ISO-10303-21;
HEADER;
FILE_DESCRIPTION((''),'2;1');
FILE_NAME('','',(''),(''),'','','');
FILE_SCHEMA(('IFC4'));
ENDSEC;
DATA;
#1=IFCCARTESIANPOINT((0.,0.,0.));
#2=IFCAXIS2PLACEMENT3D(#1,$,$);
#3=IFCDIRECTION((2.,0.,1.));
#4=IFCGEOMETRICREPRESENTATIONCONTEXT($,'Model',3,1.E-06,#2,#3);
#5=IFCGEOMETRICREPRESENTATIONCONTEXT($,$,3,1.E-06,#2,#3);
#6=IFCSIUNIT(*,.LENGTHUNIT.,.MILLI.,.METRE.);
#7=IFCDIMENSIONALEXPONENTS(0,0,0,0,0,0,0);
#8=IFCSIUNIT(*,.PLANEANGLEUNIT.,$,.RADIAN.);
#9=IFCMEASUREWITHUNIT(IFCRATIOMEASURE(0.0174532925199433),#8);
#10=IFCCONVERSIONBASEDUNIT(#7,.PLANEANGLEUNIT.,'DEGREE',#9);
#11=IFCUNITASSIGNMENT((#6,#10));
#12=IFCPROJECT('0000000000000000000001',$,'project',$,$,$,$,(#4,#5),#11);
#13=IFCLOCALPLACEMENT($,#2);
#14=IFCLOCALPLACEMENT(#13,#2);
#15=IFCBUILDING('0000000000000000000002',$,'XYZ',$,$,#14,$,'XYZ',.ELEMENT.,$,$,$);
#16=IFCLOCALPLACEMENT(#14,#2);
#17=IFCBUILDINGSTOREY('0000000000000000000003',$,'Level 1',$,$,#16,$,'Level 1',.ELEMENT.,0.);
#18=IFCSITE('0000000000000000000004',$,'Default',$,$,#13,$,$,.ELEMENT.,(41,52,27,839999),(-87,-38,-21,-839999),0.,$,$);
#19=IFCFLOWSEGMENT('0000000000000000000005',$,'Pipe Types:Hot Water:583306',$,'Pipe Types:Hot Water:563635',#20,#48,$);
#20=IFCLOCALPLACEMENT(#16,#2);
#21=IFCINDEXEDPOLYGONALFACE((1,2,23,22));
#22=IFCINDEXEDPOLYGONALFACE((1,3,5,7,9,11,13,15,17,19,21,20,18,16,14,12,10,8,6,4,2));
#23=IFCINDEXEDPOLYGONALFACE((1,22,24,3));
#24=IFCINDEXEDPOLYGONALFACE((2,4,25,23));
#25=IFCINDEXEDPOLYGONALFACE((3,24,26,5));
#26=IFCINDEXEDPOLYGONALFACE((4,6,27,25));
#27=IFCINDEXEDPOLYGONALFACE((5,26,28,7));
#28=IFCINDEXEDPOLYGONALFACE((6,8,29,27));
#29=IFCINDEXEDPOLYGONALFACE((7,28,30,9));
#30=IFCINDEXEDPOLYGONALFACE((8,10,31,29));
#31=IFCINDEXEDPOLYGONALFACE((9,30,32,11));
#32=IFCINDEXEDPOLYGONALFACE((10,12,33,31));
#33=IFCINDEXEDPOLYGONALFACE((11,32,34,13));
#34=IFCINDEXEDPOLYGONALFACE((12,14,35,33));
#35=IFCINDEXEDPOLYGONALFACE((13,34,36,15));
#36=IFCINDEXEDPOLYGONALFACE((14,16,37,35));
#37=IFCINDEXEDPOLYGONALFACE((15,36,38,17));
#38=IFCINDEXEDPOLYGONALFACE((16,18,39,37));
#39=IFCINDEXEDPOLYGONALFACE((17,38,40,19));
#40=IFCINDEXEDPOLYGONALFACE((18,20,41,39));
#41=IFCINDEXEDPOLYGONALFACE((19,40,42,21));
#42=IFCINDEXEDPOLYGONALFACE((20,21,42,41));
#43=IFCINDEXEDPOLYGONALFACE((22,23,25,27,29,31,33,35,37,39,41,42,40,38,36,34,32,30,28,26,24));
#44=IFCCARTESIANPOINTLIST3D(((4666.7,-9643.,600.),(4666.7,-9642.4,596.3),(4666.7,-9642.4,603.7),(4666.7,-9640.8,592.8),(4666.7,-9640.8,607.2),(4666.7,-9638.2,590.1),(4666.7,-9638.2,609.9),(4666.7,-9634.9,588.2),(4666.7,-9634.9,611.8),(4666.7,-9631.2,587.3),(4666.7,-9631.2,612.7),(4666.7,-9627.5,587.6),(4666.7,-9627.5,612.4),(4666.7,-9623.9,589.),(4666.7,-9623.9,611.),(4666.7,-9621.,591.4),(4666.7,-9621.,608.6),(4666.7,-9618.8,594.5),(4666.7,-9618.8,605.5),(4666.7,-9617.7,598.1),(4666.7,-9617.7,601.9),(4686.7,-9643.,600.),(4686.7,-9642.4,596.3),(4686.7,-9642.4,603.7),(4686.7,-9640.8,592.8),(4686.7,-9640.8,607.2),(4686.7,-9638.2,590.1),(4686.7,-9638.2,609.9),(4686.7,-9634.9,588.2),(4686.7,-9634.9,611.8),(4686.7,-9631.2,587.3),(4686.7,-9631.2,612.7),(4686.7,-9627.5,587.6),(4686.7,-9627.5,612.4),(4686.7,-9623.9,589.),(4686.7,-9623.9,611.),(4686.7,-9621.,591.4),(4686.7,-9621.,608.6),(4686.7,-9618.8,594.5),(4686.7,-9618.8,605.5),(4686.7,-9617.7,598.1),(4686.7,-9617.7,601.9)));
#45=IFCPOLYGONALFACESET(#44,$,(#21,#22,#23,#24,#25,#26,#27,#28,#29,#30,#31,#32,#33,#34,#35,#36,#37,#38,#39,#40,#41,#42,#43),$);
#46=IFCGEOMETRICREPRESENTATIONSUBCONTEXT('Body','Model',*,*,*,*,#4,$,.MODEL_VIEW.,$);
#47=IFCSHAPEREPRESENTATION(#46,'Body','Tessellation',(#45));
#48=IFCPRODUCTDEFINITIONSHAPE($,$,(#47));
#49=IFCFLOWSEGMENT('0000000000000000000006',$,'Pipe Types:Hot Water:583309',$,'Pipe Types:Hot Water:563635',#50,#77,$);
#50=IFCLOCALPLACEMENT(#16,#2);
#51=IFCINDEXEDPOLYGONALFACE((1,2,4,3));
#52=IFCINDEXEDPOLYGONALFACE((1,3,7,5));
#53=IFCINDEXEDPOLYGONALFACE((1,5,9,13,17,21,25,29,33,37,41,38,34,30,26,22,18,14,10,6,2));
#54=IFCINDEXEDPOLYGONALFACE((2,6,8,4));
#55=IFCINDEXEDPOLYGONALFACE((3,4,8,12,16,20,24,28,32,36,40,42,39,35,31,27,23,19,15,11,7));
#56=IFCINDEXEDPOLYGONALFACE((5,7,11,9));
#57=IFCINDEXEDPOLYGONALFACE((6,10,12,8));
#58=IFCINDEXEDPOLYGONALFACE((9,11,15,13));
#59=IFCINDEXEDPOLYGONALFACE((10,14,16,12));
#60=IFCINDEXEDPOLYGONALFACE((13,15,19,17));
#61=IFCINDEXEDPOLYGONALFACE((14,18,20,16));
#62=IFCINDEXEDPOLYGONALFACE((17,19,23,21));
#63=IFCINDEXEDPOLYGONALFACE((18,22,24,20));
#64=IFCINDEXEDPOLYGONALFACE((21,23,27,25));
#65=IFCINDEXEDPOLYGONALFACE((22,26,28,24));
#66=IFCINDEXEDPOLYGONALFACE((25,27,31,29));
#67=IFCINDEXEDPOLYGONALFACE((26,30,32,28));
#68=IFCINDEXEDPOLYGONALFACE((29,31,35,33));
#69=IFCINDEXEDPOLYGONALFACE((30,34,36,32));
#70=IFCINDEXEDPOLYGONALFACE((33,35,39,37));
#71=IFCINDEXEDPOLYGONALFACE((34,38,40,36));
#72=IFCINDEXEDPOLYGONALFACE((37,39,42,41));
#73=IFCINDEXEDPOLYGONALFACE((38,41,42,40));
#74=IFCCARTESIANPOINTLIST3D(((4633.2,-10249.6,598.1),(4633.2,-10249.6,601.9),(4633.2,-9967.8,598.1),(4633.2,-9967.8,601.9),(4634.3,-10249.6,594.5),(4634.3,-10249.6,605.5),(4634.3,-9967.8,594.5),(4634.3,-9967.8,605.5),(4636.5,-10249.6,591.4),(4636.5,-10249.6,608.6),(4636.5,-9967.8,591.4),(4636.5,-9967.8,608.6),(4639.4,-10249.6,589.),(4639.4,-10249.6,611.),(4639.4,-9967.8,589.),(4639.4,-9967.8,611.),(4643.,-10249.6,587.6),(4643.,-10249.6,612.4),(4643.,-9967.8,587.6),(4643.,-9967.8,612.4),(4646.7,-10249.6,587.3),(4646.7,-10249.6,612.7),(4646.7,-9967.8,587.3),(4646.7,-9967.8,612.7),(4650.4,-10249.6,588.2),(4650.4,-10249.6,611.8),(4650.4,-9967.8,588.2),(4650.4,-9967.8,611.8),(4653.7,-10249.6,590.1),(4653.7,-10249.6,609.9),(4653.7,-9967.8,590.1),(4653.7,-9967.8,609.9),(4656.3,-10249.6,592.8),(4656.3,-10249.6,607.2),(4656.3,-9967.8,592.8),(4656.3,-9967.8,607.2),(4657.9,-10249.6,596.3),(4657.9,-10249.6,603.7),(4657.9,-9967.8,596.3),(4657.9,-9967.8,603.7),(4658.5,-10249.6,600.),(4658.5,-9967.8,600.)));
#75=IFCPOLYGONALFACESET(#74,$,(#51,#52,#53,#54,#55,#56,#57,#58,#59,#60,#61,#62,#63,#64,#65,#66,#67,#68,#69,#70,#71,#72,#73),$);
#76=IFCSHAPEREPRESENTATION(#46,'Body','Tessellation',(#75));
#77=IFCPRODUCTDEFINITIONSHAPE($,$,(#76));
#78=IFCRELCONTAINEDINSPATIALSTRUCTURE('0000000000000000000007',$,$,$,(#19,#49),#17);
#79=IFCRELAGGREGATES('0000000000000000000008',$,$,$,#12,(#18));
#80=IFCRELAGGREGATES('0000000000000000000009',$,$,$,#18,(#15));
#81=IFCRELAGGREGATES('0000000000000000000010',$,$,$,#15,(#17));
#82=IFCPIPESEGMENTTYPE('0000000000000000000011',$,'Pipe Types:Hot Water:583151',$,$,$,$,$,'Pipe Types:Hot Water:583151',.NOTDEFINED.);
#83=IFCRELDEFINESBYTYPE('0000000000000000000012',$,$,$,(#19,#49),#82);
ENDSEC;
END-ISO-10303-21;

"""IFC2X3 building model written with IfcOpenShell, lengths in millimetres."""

from ifc_helpers import new_model, entity, si_unit, converted_unit, direction, frame, frame_2d, origin, origin_2d_with_axis, place, context, subcontext, project, spatial, circle, extrude, type_object, element, save


model = new_model("IFC2X3")

# Units and contexts
model_context = context("Model", 3, precision=1e-06, world=origin(), true_north=direction((2.0, 0.0, 1.0)))
context_of_model = context(None, 3, precision=1e-06, world=origin(), true_north=direction((2.0, 0.0, 1.0)))
body_context = subcontext(model_context, "Body", "Model", "MODEL_VIEW")
ifc_project = project(units=[si_unit("LENGTHUNIT", "METRE", prefix="MILLI"), converted_unit("PLANEANGLEUNIT", "DEGREE", entity("IfcRatioMeasure", 0.0174532925199433), si_unit("PLANEANGLEUNIT", "RADIAN"), dimensions=[0, 0, 0, 0, 0, 0, 0])], contexts=[model_context, context_of_model])

# Site, building, storey
site_placement = place(None, origin())
site = spatial("IfcSite", under=ifc_project, at=site_placement, Name="Default", CompositionType="ELEMENT", RefLatitude=(41, 52, 27, 839999), RefLongitude=(-87, -38, -21, -839999), RefElevation=0.0)
building_placement = place(site_placement, origin())
building = spatial("IfcBuilding", under=site, at=building_placement, Name="XYZ", LongName="XYZ", CompositionType="ELEMENT")
storey_placement = place(building_placement, origin())
storey = spatial("IfcBuildingStorey", under=building, at=storey_placement, Name="Level 1", LongName="Level 1", CompositionType="ELEMENT", Elevation=0.0)

# Flow segments
pipe_segment_type_1 = type_object("IfcPipeSegmentType", Name="Pipe Types:Hot Water:583151", ElementType="Pipe Types:Hot Water:583151", PredefinedType="NOTDEFINED")
flow_segment_1_placement = place(storey_placement, origin())
element("IfcFlowSegment", 1, at=flow_segment_1_placement, inside=storey, type_object=pipe_segment_type_1, Name="Pipe Types:Hot Water:583306", ObjectType="Pipe Types:Hot Water:563635", context=body_context, shape_type="SweptSolid", body=[
    extrude(circle(Radius=12.7, at=frame_2d((0.0, 0.0), x_axis=(1.0, 0.0))), frame((4666.7, -9630.3, 600.0), z_axis=(1.0, 0.0, 0.0), x_axis=(0.0, -1.0, 0.0)), (0.0, 0.0, 1.0), 20.0),
])
flow_segment_2_placement = place(storey_placement, origin())
element("IfcFlowSegment", 2, at=flow_segment_2_placement, inside=storey, type_object=pipe_segment_type_1, Name="Pipe Types:Hot Water:583309", ObjectType="Pipe Types:Hot Water:563635", context=body_context, shape_type="SweptSolid", body=[
    extrude(circle(Radius=12.7, at=origin_2d_with_axis()), frame((4645.8, -10249.6, 600.0), z_axis=(0.0, 1.0, 0.0), x_axis=(1.0, 0.0, 0.0)), (0.0, 0.0, 1.0), 281.9),
])

save(model, "model.ifc")
